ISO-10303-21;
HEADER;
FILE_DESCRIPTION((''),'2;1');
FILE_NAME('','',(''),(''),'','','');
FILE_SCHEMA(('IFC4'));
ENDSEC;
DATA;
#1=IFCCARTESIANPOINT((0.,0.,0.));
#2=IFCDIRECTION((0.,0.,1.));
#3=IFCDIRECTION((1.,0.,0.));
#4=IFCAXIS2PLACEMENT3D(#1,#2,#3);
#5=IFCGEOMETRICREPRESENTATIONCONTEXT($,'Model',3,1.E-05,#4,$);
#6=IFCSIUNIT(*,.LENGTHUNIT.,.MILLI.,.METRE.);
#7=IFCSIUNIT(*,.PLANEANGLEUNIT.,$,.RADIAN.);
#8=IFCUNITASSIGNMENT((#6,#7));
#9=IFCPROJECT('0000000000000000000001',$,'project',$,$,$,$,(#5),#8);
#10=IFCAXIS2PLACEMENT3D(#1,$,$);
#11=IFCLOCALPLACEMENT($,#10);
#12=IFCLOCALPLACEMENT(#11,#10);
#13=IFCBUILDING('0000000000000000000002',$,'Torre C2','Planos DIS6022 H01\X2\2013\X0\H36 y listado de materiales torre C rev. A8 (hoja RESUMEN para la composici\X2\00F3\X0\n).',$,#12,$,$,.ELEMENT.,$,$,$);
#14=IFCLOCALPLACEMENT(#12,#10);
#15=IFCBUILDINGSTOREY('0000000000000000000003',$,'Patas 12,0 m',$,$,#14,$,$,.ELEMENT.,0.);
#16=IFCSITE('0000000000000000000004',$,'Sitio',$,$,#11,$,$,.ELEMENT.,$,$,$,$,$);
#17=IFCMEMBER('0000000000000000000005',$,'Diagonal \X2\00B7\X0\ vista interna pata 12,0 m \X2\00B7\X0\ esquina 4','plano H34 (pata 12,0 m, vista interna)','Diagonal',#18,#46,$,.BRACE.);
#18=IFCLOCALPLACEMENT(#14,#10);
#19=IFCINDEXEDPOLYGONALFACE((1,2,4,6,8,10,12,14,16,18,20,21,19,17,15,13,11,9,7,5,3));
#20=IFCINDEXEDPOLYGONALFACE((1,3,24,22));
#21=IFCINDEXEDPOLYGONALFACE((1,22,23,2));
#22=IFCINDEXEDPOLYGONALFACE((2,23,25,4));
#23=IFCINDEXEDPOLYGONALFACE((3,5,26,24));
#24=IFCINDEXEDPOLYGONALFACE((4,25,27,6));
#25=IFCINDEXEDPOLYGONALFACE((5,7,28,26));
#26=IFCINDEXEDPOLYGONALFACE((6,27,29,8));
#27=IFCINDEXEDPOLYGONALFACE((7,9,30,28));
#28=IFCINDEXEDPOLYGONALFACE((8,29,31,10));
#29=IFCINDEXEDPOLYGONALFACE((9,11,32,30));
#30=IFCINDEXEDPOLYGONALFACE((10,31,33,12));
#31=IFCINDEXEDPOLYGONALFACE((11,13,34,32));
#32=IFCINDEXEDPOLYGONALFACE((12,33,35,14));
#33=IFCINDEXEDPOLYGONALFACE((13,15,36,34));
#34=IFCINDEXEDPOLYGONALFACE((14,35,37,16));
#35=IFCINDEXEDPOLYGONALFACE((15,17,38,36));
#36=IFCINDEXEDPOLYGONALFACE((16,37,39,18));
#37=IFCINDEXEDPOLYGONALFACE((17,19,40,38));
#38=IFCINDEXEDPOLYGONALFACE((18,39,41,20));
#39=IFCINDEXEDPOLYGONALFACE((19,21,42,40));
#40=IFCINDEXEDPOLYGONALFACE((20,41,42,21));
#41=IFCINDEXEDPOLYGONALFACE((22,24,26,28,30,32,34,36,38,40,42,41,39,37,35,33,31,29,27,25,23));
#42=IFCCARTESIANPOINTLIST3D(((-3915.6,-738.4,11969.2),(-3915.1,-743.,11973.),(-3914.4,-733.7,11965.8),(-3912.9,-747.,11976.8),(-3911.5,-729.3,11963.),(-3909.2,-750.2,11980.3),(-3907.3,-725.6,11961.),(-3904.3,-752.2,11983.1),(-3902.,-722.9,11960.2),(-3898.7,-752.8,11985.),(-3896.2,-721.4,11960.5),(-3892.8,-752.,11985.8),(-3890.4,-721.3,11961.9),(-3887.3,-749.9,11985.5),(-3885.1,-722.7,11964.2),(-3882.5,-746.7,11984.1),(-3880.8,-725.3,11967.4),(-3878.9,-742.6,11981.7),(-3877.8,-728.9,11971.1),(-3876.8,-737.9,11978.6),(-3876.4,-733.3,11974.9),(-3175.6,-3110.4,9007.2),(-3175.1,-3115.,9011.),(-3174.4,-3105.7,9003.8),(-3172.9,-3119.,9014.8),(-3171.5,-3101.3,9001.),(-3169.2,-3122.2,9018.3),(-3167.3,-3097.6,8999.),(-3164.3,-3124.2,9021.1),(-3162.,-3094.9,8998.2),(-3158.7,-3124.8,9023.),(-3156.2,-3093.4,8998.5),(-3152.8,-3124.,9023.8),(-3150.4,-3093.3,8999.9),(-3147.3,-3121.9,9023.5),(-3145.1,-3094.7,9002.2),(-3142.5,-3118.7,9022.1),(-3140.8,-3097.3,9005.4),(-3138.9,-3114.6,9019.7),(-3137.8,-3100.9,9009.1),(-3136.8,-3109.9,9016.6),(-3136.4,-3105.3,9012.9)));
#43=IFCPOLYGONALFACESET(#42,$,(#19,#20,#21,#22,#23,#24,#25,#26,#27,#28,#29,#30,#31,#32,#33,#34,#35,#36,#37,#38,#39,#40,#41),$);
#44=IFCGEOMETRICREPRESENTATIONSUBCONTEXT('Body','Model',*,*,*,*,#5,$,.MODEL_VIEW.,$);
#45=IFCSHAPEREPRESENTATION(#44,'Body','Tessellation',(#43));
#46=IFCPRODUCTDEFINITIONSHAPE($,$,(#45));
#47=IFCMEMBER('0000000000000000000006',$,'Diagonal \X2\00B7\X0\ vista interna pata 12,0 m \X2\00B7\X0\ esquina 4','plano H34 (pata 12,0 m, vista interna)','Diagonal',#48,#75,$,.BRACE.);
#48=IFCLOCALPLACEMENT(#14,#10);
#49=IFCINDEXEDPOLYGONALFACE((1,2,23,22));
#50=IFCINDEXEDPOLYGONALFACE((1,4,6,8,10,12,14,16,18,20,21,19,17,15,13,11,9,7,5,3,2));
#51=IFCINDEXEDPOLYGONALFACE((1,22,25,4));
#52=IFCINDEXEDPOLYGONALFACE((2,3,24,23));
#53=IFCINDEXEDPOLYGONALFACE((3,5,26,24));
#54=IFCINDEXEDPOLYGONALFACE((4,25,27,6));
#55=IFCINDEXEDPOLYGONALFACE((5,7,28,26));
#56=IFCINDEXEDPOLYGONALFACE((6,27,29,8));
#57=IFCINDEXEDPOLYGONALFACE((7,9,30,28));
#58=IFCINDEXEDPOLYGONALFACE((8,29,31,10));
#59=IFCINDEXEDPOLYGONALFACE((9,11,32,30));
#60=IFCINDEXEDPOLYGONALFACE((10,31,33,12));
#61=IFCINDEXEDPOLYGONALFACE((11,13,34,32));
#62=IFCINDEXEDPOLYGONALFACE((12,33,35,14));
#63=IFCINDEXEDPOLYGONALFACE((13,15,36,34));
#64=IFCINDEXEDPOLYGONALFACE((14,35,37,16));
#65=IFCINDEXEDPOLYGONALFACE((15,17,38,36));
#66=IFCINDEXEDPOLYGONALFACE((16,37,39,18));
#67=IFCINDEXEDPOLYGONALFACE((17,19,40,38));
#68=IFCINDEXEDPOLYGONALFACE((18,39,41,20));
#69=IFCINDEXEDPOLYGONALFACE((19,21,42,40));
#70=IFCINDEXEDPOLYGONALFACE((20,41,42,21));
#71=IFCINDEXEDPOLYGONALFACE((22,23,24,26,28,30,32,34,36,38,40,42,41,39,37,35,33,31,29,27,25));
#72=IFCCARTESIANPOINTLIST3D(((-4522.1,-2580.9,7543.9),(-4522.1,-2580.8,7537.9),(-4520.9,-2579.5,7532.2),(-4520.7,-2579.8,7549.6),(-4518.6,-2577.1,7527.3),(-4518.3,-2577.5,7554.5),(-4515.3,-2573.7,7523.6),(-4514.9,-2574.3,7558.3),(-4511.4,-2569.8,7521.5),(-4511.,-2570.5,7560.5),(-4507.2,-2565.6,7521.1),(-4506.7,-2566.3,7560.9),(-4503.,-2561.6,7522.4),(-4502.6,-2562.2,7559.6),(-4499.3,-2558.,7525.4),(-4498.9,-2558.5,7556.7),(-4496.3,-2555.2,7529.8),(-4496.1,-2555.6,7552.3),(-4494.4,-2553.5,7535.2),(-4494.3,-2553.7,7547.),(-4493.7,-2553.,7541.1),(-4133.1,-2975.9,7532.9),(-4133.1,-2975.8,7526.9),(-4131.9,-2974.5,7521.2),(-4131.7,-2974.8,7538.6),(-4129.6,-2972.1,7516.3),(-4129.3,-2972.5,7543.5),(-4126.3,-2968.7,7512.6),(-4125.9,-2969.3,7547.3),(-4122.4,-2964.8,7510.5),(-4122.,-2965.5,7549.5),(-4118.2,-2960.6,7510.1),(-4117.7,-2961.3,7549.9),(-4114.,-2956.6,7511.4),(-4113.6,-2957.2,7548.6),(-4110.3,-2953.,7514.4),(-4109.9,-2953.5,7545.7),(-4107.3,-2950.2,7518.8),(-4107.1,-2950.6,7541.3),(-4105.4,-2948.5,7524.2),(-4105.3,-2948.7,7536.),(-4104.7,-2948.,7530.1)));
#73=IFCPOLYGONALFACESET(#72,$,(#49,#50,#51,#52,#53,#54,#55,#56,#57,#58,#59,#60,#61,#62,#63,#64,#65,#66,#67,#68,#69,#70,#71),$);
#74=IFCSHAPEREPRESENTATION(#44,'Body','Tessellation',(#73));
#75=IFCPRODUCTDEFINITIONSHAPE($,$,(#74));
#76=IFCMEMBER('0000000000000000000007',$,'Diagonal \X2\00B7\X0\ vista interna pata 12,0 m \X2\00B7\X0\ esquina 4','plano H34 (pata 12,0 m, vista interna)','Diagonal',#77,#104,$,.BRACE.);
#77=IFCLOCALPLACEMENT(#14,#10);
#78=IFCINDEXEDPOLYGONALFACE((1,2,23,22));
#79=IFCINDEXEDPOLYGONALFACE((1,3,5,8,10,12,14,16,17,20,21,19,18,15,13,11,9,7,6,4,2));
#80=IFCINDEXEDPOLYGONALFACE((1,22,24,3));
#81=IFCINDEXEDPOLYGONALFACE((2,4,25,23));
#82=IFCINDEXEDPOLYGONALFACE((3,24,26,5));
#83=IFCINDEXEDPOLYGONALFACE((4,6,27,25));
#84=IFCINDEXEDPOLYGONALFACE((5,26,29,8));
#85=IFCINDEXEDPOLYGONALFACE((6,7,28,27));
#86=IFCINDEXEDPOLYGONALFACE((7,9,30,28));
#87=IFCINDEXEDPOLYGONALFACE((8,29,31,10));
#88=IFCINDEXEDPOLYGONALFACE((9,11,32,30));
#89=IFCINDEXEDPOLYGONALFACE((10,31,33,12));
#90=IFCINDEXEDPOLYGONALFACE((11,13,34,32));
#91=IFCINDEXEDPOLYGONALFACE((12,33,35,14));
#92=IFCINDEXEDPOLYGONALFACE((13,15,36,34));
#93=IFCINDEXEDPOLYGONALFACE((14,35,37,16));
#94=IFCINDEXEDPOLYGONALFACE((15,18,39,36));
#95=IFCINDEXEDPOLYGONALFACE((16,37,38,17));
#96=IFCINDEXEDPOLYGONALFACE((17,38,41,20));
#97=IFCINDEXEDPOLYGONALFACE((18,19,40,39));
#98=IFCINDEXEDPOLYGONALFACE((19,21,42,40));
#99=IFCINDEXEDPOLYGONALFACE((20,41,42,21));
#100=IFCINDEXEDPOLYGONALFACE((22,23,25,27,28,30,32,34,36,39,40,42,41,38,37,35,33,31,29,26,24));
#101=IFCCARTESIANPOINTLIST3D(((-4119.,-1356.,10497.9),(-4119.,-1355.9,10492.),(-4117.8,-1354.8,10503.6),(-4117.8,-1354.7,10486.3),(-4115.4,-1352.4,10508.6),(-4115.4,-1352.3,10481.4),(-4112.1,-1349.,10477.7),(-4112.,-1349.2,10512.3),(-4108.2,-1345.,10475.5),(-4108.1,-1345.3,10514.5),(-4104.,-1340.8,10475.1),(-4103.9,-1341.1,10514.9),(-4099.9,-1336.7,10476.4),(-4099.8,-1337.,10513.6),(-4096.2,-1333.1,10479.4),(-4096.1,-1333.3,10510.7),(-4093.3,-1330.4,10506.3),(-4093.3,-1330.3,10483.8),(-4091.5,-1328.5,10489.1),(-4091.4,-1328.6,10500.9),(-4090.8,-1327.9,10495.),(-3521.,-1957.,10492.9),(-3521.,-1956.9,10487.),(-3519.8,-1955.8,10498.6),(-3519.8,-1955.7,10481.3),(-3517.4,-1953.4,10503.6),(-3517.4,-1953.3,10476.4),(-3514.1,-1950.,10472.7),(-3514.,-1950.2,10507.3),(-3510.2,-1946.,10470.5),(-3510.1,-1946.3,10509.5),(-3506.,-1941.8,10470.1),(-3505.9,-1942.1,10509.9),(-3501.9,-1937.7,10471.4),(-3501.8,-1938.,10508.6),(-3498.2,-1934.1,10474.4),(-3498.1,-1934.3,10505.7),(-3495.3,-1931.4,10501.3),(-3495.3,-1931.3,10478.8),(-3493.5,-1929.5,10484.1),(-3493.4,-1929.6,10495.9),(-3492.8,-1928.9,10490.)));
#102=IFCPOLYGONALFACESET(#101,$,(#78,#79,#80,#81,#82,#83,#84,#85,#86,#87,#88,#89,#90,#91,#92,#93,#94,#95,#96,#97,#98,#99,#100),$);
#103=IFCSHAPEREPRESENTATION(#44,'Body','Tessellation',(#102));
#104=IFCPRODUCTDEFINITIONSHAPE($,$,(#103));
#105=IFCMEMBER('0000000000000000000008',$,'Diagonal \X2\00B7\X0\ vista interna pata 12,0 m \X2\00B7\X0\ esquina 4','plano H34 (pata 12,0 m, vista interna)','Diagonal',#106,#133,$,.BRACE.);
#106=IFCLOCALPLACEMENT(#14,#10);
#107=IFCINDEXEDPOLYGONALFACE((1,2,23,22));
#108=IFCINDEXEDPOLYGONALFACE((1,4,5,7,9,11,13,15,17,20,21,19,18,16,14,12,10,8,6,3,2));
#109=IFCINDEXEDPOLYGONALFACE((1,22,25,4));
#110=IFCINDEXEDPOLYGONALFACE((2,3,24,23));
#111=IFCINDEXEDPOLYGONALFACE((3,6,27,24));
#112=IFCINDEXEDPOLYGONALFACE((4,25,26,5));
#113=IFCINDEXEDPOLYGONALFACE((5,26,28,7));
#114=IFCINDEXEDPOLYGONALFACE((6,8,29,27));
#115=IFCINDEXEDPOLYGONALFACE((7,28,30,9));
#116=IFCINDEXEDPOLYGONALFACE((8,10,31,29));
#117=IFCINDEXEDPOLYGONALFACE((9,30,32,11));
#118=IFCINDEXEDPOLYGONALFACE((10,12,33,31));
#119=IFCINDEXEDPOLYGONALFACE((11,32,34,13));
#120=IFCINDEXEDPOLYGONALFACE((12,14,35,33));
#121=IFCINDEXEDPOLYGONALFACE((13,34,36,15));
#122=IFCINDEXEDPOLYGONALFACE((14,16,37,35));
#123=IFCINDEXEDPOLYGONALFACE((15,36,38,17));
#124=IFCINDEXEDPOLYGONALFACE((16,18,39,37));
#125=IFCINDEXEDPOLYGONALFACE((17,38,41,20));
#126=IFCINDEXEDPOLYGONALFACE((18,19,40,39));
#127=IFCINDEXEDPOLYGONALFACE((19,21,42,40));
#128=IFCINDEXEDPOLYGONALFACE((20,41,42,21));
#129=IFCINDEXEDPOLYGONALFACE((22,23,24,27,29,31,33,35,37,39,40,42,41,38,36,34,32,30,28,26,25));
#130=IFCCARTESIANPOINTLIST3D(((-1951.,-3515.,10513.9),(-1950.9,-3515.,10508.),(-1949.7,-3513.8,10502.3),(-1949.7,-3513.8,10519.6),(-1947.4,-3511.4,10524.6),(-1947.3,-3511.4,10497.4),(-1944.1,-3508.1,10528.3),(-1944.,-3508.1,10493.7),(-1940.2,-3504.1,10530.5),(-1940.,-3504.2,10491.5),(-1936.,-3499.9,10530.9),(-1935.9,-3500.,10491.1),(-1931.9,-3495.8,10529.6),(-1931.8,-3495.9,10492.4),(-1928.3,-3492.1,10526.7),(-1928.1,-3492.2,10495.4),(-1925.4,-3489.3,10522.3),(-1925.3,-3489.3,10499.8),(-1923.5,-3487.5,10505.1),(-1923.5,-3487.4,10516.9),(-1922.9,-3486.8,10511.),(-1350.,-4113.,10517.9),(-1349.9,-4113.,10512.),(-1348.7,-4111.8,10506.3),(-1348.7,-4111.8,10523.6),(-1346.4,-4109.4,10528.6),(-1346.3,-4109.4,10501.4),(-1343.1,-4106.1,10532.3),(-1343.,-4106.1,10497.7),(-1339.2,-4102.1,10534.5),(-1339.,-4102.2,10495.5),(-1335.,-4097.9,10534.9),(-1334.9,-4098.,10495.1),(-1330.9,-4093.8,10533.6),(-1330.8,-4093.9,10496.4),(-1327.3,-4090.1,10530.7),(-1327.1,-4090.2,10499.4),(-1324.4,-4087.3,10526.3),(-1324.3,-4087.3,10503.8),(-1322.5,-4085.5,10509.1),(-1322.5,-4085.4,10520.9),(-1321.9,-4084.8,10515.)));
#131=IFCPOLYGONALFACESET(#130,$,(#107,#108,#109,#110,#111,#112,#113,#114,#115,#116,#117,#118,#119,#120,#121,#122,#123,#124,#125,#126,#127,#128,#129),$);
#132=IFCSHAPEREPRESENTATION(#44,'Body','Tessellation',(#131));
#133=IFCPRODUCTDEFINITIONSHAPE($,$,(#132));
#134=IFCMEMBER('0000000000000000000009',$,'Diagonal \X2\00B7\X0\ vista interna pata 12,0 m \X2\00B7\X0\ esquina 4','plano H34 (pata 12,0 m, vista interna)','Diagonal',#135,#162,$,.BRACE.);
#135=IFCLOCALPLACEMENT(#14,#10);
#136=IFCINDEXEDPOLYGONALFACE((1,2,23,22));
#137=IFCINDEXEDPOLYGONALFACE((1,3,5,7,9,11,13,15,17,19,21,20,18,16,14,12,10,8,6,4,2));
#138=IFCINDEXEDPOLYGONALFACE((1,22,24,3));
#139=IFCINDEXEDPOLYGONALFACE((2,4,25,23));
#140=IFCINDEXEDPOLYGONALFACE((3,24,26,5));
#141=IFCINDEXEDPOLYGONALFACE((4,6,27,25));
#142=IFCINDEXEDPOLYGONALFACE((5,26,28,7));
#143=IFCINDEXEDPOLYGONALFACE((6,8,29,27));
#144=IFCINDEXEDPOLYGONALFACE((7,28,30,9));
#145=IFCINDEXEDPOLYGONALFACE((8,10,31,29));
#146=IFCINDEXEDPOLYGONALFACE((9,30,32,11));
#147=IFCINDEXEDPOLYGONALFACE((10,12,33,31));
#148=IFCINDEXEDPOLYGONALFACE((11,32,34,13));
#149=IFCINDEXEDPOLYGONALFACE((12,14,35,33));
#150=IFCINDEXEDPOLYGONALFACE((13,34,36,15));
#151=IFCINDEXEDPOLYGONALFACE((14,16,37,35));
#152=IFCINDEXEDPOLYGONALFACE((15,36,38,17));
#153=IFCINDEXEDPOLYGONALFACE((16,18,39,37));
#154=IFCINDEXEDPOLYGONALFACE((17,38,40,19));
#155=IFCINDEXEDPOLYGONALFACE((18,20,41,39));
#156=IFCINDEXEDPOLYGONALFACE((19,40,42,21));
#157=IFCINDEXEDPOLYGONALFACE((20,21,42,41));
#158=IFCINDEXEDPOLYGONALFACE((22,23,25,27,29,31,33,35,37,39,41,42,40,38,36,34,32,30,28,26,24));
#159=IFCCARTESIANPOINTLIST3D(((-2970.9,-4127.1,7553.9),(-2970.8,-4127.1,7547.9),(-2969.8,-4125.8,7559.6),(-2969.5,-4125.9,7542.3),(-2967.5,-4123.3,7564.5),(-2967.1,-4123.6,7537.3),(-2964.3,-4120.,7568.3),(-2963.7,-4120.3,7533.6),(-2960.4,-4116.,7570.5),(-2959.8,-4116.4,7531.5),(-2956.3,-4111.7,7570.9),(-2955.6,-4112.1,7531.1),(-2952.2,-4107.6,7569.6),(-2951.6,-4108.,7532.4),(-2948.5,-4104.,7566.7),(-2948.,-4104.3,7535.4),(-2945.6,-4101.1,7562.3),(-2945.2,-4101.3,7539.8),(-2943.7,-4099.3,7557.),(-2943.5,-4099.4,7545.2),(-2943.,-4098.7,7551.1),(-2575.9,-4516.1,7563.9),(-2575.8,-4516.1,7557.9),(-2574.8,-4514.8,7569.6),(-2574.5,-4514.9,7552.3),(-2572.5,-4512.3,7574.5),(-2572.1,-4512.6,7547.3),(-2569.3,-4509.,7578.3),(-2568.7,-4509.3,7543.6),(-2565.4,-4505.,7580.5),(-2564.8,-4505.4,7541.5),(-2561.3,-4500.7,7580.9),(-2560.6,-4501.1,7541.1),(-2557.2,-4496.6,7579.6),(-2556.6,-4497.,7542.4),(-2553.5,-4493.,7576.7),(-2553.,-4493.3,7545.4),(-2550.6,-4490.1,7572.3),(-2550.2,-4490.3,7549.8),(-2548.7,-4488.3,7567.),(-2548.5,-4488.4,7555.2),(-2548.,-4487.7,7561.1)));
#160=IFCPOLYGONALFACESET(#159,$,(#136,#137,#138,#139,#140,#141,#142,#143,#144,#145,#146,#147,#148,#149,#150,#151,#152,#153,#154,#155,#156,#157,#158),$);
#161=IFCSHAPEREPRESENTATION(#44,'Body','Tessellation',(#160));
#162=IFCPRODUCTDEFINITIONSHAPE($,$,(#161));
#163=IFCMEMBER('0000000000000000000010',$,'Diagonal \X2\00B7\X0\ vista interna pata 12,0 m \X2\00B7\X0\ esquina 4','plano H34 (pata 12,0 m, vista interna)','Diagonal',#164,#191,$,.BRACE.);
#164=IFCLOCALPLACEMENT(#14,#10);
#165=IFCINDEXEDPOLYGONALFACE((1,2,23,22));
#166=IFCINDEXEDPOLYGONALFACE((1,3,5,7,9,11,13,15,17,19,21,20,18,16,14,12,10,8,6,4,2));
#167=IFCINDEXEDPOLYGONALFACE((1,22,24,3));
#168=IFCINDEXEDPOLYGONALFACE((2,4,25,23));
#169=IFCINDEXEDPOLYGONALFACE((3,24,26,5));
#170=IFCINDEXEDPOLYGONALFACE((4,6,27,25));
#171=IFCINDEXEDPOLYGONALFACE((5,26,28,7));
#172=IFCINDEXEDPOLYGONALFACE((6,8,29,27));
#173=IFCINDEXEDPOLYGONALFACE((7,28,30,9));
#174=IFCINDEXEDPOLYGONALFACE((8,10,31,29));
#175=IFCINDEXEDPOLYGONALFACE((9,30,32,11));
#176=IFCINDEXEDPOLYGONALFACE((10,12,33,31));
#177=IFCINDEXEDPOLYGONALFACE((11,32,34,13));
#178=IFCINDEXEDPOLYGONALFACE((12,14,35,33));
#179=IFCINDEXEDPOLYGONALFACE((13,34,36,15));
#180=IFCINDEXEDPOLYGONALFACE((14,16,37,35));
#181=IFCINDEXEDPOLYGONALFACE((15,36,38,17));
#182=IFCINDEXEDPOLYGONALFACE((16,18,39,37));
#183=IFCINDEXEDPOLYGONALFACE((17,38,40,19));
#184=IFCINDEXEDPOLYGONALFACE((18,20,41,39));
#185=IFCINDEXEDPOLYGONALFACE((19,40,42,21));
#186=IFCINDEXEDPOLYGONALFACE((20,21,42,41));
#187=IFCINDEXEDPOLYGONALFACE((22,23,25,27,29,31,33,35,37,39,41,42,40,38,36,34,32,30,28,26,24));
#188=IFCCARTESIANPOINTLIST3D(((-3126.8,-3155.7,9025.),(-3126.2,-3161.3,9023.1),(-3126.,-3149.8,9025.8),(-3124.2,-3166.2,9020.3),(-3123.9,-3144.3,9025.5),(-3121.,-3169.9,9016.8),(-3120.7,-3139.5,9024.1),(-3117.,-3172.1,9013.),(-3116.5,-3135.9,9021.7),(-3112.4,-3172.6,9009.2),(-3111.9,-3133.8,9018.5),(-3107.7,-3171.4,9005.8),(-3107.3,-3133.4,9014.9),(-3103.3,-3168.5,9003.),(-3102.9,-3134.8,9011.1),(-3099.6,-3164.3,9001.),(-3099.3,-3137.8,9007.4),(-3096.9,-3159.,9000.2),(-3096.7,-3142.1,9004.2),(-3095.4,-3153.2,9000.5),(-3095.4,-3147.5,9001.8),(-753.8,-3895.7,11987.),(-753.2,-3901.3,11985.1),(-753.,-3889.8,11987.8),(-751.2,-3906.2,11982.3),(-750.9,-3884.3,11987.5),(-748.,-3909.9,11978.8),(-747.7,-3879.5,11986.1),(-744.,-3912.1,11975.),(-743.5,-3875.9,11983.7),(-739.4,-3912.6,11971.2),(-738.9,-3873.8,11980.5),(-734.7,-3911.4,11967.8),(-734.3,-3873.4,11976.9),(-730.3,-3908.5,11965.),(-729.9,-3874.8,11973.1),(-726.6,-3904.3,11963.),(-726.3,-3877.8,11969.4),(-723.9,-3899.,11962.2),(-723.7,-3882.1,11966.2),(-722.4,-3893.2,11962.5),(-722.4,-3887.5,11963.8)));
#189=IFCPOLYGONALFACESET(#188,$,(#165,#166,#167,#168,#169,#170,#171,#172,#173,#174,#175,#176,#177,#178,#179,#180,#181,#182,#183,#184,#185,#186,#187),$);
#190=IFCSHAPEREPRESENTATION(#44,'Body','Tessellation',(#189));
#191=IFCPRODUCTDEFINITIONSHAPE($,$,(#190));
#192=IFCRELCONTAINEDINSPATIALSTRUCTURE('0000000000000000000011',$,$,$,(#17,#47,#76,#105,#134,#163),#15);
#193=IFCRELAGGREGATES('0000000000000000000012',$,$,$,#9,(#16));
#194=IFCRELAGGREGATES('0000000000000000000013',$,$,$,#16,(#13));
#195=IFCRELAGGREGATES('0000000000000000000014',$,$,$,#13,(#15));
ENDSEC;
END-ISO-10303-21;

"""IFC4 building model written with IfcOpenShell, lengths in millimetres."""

from ifc_helpers import new_model, si_unit, frame, origin, origin_with_axes, place, context, subcontext, project, spatial, circle, extrude, element, save


model = new_model("IFC4")

# Units and contexts
model_context = context("Model", 3, precision=1e-05, world=origin_with_axes())
body_context = subcontext(model_context, "Body", "Model", "MODEL_VIEW")
ifc_project = project(units=[si_unit("LENGTHUNIT", "METRE", prefix="MILLI"), si_unit("PLANEANGLEUNIT", "RADIAN")], contexts=[model_context])

# Site, building, storey
site_placement = place(None, origin())
site = spatial("IfcSite", under=ifc_project, at=site_placement, Name="Sitio", CompositionType="ELEMENT")
building_placement = place(site_placement, origin())
building = spatial("IfcBuilding", under=site, at=building_placement, Name="Torre C2", Description="Planos DIS6022 H01–H36 y listado de materiales torre C rev. A8 (hoja RESUMEN para la composición).", CompositionType="ELEMENT")
storey_placement = place(building_placement, origin())
storey = spatial("IfcBuildingStorey", under=building, at=storey_placement, Name="Patas 12,0 m", CompositionType="ELEMENT", Elevation=0.0)

# Members
member_1_placement = place(storey_placement, frame((-3896.0, -737.0, 11973.0), z_axis=(0.191403, -0.613524, -0.766129), x_axis=(0.9092, 0.404881, -0.097086)))
element("IfcMember", 1, at=member_1_placement, inside=storey, Name="Diagonal · vista interna pata 12,0 m · esquina 4", Description="plano H34 (pata 12,0 m, vista interna)", ObjectType="Diagonal", PredefinedType="BRACE", context=body_context, shape_type="SweptSolid", body=[
    extrude(circle(Radius=20.0), None, (0.0, 0.0, 1.0), 3866.2),
])
member_2_placement = place(storey_placement, frame((-4508.0, -2567.0, 7541.0), z_axis=(0.701537, -0.712357, -0.019838), x_axis=(0.712549, 0.701609, 0.004182)))
element("IfcMember", 2, at=member_2_placement, inside=storey, Name="Diagonal · vista interna pata 12,0 m · esquina 4", Description="plano H34 (pata 12,0 m, vista interna)", ObjectType="Diagonal", PredefinedType="BRACE", context=body_context, shape_type="SweptSolid", body=[
    extrude(circle(Radius=20.0), None, (0.0, 0.0, 1.0), 554.5),
])
member_3_placement = place(storey_placement, frame((-4105.0, -1342.0, 10495.0), z_axis=(0.705323, -0.708861, -0.005897), x_axis=(0.708882, 0.705324, 0.002325)))
element("IfcMember", 3, at=member_3_placement, inside=storey, Name="Diagonal · vista interna pata 12,0 m · esquina 4", Description="plano H34 (pata 12,0 m, vista interna)", ObjectType="Diagonal", PredefinedType="BRACE", context=body_context, shape_type="SweptSolid", body=[
    extrude(circle(Radius=20.0), None, (0.0, 0.0, 1.0), 847.8),
])
member_4_placement = place(storey_placement, frame((-1937.0, -3501.0, 10511.0), z_axis=(0.708866, -0.705327, 0.004718), x_axis=(0.705328, 0.708879, 0.001864)))
element("IfcMember", 4, at=member_4_placement, inside=storey, Name="Diagonal · vista interna pata 12,0 m · esquina 4", Description="plano H34 (pata 12,0 m, vista interna)", ObjectType="Diagonal", PredefinedType="BRACE", context=body_context, shape_type="SweptSolid", body=[
    extrude(circle(Radius=20.0), None, (0.0, 0.0, 1.0), 847.8),
])
member_5_placement = place(storey_placement, frame((-2957.0, -4113.0, 7551.0), z_axis=(0.712382, -0.701561, 0.018035), x_axis=(0.701621, 0.71254, 0.003805)))
element("IfcMember", 5, at=member_5_placement, inside=storey, Name="Diagonal · vista interna pata 12,0 m · esquina 4", Description="plano H34 (pata 12,0 m, vista interna)", ObjectType="Diagonal", PredefinedType="BRACE", context=body_context, shape_type="SweptSolid", body=[
    extrude(circle(Radius=20.0), None, (0.0, 0.0, 1.0), 554.5),
])
member_6_placement = place(storey_placement, frame((-3111.0, -3153.0, 9013.0), z_axis=(0.613685, -0.191373, 0.766007), x_axis=(0.405164, 0.909031, -0.097492)))
element("IfcMember", 6, at=member_6_placement, inside=storey, Name="Diagonal · vista interna pata 12,0 m · esquina 4", Description="plano H34 (pata 12,0 m, vista interna)", ObjectType="Diagonal", PredefinedType="BRACE", context=body_context, shape_type="SweptSolid", body=[
    extrude(circle(Radius=20.0), None, (0.0, 0.0, 1.0), 3866.8),
])

save(model, "model.ifc")
